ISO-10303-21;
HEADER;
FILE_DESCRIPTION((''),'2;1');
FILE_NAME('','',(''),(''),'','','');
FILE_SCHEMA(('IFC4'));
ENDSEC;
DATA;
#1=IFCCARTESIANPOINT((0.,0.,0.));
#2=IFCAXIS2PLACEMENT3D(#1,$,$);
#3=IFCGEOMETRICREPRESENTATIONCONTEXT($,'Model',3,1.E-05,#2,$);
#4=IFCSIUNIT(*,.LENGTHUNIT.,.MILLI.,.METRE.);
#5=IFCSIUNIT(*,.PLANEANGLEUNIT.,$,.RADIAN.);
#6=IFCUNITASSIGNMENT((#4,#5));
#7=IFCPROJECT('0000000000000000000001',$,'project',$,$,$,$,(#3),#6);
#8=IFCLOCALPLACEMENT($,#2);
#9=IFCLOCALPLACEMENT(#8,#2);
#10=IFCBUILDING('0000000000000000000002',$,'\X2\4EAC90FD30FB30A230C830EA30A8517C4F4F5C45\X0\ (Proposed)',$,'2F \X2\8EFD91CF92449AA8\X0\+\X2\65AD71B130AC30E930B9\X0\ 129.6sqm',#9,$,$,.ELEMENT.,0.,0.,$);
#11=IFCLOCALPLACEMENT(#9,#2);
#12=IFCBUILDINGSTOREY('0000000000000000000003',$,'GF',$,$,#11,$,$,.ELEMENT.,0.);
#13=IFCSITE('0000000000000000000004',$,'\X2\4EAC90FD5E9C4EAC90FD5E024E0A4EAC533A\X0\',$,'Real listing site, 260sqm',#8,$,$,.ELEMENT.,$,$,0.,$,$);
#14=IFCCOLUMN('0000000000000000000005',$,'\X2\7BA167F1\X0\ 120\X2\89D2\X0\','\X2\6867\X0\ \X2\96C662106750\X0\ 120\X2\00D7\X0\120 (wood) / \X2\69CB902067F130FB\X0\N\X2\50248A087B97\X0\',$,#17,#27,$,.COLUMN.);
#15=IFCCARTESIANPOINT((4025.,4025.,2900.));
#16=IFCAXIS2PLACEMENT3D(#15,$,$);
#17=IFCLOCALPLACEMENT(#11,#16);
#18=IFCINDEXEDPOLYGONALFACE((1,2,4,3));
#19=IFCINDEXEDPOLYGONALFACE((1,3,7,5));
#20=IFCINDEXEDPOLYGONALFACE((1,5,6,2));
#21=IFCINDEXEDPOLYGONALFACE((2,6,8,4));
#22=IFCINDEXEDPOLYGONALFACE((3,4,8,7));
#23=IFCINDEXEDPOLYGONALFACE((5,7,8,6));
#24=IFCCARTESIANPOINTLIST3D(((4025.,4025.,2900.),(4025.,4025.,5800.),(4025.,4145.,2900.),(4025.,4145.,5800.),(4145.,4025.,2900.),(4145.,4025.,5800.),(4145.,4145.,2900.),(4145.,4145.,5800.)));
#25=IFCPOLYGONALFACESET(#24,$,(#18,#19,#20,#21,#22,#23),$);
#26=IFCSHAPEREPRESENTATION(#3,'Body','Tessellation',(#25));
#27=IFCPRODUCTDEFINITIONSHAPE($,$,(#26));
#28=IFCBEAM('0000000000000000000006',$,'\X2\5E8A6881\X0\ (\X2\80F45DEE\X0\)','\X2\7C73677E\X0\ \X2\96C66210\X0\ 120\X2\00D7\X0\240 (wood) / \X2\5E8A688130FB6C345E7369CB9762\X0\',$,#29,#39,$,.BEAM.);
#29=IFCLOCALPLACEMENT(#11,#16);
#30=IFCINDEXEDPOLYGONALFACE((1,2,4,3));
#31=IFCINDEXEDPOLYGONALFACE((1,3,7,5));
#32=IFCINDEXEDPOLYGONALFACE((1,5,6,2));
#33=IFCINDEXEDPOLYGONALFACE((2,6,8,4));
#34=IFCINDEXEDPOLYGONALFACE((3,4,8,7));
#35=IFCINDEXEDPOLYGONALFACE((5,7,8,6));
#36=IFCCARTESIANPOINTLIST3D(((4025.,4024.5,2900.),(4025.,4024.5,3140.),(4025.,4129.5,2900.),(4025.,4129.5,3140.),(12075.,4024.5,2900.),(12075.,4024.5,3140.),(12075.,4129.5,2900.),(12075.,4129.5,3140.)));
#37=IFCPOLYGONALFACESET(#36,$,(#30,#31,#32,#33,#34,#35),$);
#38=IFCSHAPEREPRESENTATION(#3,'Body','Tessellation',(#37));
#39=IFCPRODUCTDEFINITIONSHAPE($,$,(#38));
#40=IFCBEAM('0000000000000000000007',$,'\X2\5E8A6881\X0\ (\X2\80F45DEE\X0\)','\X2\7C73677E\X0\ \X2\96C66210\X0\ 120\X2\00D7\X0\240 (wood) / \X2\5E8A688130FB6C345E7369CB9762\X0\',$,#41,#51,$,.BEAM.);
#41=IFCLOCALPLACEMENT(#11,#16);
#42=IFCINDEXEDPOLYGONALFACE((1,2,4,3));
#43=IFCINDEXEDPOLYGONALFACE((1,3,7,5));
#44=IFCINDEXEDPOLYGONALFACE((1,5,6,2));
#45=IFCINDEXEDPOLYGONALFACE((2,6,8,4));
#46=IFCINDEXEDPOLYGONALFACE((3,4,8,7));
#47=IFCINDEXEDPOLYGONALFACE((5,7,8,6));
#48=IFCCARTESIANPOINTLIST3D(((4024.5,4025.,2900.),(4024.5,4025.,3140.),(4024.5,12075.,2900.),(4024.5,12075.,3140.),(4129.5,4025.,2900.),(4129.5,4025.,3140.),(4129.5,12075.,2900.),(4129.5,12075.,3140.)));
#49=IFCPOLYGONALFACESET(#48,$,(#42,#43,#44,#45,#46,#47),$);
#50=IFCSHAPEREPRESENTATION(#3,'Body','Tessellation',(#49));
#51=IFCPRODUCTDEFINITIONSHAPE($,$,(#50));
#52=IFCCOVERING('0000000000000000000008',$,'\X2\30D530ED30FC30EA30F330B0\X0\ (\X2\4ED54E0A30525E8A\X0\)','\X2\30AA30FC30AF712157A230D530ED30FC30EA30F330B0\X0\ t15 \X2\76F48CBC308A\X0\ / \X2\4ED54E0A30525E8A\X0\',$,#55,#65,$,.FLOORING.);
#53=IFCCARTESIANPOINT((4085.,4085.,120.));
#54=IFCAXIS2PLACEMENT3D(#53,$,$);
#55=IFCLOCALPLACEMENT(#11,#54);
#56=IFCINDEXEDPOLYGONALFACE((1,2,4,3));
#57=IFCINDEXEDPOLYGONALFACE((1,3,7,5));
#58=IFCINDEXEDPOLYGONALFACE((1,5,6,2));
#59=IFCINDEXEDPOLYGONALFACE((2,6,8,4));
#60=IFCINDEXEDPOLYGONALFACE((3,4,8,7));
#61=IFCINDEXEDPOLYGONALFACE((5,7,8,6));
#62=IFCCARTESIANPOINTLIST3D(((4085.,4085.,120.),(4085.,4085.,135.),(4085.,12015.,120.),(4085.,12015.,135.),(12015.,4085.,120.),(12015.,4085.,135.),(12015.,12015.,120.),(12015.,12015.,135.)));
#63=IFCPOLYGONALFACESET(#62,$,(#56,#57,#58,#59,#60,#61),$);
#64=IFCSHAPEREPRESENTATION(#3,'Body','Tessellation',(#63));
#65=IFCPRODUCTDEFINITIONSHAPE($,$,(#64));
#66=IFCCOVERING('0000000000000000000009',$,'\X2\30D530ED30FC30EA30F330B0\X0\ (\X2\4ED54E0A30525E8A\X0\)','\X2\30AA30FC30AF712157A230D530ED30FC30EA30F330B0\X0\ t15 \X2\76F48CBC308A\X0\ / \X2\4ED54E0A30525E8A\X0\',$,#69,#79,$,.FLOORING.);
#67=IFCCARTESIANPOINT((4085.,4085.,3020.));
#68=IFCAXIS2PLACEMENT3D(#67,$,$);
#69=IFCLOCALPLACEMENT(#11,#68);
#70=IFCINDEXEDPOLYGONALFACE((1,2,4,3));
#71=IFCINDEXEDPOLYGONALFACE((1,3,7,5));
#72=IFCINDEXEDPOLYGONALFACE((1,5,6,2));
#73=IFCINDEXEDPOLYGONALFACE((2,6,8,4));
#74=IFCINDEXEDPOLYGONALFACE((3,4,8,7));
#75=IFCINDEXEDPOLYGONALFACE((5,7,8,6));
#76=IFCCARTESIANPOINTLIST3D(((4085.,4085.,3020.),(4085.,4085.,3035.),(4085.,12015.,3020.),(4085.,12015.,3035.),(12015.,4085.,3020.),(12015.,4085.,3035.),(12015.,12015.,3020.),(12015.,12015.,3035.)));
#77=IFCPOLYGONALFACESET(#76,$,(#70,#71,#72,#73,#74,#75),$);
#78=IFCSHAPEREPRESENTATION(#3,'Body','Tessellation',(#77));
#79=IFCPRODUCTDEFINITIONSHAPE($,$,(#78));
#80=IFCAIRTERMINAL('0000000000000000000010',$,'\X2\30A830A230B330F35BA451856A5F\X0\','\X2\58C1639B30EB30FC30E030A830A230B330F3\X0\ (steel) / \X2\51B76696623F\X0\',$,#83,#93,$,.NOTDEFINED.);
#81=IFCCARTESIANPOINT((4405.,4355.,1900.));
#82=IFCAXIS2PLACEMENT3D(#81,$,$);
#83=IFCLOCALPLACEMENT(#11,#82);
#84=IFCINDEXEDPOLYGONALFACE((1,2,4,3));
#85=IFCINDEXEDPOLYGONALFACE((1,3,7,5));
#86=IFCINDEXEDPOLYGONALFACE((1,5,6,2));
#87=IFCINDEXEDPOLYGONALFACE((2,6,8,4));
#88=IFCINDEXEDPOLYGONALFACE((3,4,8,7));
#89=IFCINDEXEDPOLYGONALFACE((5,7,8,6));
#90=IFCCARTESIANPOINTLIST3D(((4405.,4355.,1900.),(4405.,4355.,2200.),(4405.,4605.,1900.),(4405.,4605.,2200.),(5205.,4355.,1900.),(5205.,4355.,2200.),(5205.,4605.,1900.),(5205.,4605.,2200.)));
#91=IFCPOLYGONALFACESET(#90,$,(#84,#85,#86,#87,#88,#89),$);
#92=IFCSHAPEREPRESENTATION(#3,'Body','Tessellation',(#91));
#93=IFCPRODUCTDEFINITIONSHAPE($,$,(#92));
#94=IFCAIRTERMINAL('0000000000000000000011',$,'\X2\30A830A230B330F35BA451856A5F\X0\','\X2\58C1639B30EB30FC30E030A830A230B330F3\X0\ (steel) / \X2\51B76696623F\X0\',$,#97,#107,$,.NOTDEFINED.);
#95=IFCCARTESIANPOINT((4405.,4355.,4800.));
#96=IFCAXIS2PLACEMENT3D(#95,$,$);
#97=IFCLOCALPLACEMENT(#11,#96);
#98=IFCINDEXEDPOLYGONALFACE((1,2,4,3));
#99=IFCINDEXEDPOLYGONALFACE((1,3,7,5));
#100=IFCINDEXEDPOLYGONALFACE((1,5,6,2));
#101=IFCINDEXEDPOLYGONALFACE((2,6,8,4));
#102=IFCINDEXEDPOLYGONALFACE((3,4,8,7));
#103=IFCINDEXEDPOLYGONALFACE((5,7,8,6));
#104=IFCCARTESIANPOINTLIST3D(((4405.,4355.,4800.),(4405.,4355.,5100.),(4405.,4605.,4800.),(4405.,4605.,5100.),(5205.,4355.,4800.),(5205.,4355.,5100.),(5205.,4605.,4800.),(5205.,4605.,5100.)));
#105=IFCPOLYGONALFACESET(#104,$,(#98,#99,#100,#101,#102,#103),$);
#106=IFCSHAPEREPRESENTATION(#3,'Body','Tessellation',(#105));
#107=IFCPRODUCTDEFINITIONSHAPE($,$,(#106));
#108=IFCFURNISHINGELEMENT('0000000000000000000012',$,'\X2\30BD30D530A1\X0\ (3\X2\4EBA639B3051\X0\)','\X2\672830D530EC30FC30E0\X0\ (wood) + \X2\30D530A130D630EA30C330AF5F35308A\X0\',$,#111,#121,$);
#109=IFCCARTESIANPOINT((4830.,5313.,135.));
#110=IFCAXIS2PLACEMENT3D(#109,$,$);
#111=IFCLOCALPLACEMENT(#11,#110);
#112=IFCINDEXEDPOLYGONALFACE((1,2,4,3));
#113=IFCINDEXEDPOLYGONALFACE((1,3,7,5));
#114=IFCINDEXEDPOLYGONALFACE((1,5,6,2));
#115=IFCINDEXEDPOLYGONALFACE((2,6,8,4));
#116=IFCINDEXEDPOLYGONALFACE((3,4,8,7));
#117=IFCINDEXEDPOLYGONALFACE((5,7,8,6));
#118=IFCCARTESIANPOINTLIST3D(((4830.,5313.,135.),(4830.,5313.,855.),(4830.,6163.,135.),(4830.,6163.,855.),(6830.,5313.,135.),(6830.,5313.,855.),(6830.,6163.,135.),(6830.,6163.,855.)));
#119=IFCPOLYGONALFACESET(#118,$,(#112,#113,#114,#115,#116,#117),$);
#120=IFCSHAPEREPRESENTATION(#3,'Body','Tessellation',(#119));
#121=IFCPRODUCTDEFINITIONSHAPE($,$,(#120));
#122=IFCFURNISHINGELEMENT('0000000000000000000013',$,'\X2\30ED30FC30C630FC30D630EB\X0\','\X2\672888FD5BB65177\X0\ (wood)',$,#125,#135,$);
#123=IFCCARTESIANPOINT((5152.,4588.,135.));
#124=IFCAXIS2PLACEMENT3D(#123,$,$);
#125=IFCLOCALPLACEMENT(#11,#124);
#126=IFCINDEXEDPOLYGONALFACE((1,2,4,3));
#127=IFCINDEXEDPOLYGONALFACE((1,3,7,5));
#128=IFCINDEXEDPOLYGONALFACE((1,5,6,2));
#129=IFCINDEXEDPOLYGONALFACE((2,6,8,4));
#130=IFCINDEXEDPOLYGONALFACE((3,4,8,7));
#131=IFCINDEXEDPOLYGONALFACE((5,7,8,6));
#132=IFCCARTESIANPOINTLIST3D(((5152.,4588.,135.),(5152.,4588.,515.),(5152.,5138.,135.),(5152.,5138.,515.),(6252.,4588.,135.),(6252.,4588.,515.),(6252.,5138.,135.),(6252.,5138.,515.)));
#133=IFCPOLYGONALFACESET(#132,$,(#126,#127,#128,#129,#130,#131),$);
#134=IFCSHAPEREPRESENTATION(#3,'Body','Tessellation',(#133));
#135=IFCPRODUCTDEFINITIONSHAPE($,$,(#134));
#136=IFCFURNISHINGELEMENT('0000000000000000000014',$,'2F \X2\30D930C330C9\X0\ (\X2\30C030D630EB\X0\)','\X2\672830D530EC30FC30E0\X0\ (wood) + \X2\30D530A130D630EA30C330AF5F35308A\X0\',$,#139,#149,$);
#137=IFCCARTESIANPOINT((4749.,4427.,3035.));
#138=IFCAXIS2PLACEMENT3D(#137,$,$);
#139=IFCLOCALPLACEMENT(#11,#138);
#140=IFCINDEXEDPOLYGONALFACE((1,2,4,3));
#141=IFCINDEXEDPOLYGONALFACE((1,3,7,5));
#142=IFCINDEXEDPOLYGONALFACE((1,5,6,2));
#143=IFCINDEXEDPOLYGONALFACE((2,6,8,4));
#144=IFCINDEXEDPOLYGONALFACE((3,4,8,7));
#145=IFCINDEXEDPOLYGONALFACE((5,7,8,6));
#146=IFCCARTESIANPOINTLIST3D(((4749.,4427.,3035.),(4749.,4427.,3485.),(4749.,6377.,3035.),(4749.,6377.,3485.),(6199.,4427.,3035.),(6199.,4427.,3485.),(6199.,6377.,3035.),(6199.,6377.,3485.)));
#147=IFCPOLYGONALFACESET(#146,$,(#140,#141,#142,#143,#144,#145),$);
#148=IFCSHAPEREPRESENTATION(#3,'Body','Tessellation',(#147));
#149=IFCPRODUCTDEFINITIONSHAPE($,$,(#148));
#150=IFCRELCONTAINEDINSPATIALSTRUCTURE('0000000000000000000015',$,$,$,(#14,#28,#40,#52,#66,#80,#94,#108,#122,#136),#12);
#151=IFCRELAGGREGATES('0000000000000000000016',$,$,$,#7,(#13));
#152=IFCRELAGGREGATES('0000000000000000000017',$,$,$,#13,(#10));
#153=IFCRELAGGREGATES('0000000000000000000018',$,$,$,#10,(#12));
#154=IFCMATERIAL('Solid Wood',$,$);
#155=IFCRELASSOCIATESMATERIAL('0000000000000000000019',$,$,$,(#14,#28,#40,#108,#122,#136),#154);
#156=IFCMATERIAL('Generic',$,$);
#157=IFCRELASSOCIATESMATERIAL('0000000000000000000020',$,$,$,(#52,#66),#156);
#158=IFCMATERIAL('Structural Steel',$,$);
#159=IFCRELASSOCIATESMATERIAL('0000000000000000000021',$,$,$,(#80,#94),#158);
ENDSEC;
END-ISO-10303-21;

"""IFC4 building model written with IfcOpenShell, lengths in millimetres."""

from ifc_helpers import new_model, si_unit, frame, frame_2d, origin, place, context, project, spatial, rectangle, extrude, material, element, save


model = new_model("IFC4")

# Units and contexts
model_context = context("Model", 3, precision=1e-05, world=origin())
ifc_project = project(units=[si_unit("LENGTHUNIT", "METRE", prefix="MILLI"), si_unit("PLANEANGLEUNIT", "RADIAN")], contexts=[model_context])

# Site, building, storey
site_placement = place(None, origin())
site = spatial("IfcSite", under=ifc_project, at=site_placement, Name="京都府京都市上京区", ObjectType="Real listing site, 260sqm", CompositionType="ELEMENT", RefElevation=0.0)
building_placement = place(site_placement, origin())
building = spatial("IfcBuilding", under=site, at=building_placement, Name="京都・アトリエ兼住居 (Proposed)", ObjectType="2F 軽量鉄骨+断熱ガラス 129.6sqm", CompositionType="ELEMENT", ElevationOfRefHeight=0.0, ElevationOfTerrain=0.0)
storey_placement = place(building_placement, origin())
storey = spatial("IfcBuildingStorey", under=building, at=storey_placement, Name="GF", CompositionType="ELEMENT", Elevation=0.0)

# Column
ifc_material_1 = material(Name="Solid Wood")
column_placement = place(storey_placement, frame((4025.0, 4025.0, 2900.0)))
element("IfcColumn", 1, at=column_placement, inside=storey, material=ifc_material_1, Name="管柱 120角", Description="桧 集成材 120×120 (wood) / 構造柱・N値計算", PredefinedType="COLUMN", context=model_context, shape_type="SweptSolid", body=[
    extrude(rectangle(XDim=120.0, YDim=120.0, at=frame_2d((60.0, 60.0))), frame((4025.0, 4025.0, 2900.0)), (0.0, 0.0, 1.0), 2900.0),
])

# Beams
beam_1_placement = place(storey_placement, frame((4025.0, 4025.0, 2900.0)))
element("IfcBeam", 2, at=beam_1_placement, inside=storey, material=ifc_material_1, Name="床梁 (胴差)", Description="米松 集成 120×240 (wood) / 床梁・水平構面", PredefinedType="BEAM", context=model_context, shape_type="SweptSolid", body=[
    extrude(rectangle(XDim=8050.0, YDim=105.0, at=frame_2d((4025.0, 52.0))), frame((4025.0, 4025.0, 2900.0)), (0.0, 0.0, 1.0), 240.0),
])
beam_2_placement = place(storey_placement, frame((4025.0, 4025.0, 2900.0)))
element("IfcBeam", 3, at=beam_2_placement, inside=storey, material=ifc_material_1, Name="床梁 (胴差)", Description="米松 集成 120×240 (wood) / 床梁・水平構面", PredefinedType="BEAM", context=model_context, shape_type="SweptSolid", body=[
    extrude(rectangle(XDim=105.0, YDim=8050.0, at=frame_2d((52.0, 4025.0))), frame((4025.0, 4025.0, 2900.0)), (0.0, 0.0, 1.0), 240.0),
])

# Coverings
ifc_material_2 = material(Name="Generic")
covering_1_placement = place(storey_placement, frame((4085.0, 4085.0, 120.0)))
element("IfcCovering", 4, at=covering_1_placement, inside=storey, material=ifc_material_2, Name="フローリング (仕上げ床)", Description="オーク無垢フローリング t15 直貼り / 仕上げ床", PredefinedType="FLOORING", context=model_context, shape_type="SweptSolid", body=[
    extrude(rectangle(XDim=7930.0, YDim=7930.0, at=frame_2d((3965.0, 3965.0))), frame((4085.0, 4085.0, 120.0)), (0.0, 0.0, 1.0), 15.0),
])
covering_2_placement = place(storey_placement, frame((4085.0, 4085.0, 3020.0)))
element("IfcCovering", 5, at=covering_2_placement, inside=storey, material=ifc_material_2, Name="フローリング (仕上げ床)", Description="オーク無垢フローリング t15 直貼り / 仕上げ床", PredefinedType="FLOORING", context=model_context, shape_type="SweptSolid", body=[
    extrude(rectangle(XDim=7930.0, YDim=7930.0, at=frame_2d((3965.0, 3965.0))), frame((4085.0, 4085.0, 3020.0)), (0.0, 0.0, 1.0), 15.0),
])

# Air terminals
ifc_material_3 = material(Name="Structural Steel")
air_terminal_1_placement = place(storey_placement, frame((4405.0, 4355.0, 1900.0)))
element("IfcAirTerminal", 6, at=air_terminal_1_placement, inside=storey, material=ifc_material_3, Name="エアコン室内機", Description="壁掛ルームエアコン (steel) / 冷暖房", PredefinedType="NOTDEFINED", context=model_context, shape_type="SweptSolid", body=[
    extrude(rectangle(XDim=800.0, YDim=250.0, at=frame_2d((400.0, 125.0))), frame((4405.0, 4355.0, 1900.0)), (0.0, 0.0, 1.0), 300.0),
])
air_terminal_2_placement = place(storey_placement, frame((4405.0, 4355.0, 4800.0)))
element("IfcAirTerminal", 7, at=air_terminal_2_placement, inside=storey, material=ifc_material_3, Name="エアコン室内機", Description="壁掛ルームエアコン (steel) / 冷暖房", PredefinedType="NOTDEFINED", context=model_context, shape_type="SweptSolid", body=[
    extrude(rectangle(XDim=800.0, YDim=250.0, at=frame_2d((400.0, 125.0))), frame((4405.0, 4355.0, 4800.0)), (0.0, 0.0, 1.0), 300.0),
])

# Furnishing elements
furnishing_1_placement = place(storey_placement, frame((4830.0, 5313.0, 135.0)))
element("IfcFurnishingElement", 8, at=furnishing_1_placement, inside=storey, material=ifc_material_1, Name="ソファ (3人掛け)", Description="木フレーム (wood) + ファブリック張り", context=model_context, shape_type="SweptSolid", body=[
    extrude(rectangle(XDim=2000.0, YDim=850.0, at=frame_2d((1000.0, 425.0))), frame((4830.0, 5313.0, 135.0)), (0.0, 0.0, 1.0), 720.0),
])
furnishing_2_placement = place(storey_placement, frame((5152.0, 4588.0, 135.0)))
element("IfcFurnishingElement", 9, at=furnishing_2_placement, inside=storey, material=ifc_material_1, Name="ローテーブル", Description="木製家具 (wood)", context=model_context, shape_type="SweptSolid", body=[
    extrude(rectangle(XDim=1100.0, YDim=550.0, at=frame_2d((550.0, 275.0))), frame((5152.0, 4588.0, 135.0)), (0.0, 0.0, 1.0), 380.0),
])
furnishing_3_placement = place(storey_placement, frame((4749.0, 4427.0, 3035.0)))
element("IfcFurnishingElement", 10, at=furnishing_3_placement, inside=storey, material=ifc_material_1, Name="2F ベッド (ダブル)", Description="木フレーム (wood) + ファブリック張り", context=model_context, shape_type="SweptSolid", body=[
    extrude(rectangle(XDim=1450.0, YDim=1950.0, at=frame_2d((725.0, 975.0))), frame((4749.0, 4427.0, 3035.0)), (0.0, 0.0, 1.0), 450.0),
])

save(model, "model.ifc")
